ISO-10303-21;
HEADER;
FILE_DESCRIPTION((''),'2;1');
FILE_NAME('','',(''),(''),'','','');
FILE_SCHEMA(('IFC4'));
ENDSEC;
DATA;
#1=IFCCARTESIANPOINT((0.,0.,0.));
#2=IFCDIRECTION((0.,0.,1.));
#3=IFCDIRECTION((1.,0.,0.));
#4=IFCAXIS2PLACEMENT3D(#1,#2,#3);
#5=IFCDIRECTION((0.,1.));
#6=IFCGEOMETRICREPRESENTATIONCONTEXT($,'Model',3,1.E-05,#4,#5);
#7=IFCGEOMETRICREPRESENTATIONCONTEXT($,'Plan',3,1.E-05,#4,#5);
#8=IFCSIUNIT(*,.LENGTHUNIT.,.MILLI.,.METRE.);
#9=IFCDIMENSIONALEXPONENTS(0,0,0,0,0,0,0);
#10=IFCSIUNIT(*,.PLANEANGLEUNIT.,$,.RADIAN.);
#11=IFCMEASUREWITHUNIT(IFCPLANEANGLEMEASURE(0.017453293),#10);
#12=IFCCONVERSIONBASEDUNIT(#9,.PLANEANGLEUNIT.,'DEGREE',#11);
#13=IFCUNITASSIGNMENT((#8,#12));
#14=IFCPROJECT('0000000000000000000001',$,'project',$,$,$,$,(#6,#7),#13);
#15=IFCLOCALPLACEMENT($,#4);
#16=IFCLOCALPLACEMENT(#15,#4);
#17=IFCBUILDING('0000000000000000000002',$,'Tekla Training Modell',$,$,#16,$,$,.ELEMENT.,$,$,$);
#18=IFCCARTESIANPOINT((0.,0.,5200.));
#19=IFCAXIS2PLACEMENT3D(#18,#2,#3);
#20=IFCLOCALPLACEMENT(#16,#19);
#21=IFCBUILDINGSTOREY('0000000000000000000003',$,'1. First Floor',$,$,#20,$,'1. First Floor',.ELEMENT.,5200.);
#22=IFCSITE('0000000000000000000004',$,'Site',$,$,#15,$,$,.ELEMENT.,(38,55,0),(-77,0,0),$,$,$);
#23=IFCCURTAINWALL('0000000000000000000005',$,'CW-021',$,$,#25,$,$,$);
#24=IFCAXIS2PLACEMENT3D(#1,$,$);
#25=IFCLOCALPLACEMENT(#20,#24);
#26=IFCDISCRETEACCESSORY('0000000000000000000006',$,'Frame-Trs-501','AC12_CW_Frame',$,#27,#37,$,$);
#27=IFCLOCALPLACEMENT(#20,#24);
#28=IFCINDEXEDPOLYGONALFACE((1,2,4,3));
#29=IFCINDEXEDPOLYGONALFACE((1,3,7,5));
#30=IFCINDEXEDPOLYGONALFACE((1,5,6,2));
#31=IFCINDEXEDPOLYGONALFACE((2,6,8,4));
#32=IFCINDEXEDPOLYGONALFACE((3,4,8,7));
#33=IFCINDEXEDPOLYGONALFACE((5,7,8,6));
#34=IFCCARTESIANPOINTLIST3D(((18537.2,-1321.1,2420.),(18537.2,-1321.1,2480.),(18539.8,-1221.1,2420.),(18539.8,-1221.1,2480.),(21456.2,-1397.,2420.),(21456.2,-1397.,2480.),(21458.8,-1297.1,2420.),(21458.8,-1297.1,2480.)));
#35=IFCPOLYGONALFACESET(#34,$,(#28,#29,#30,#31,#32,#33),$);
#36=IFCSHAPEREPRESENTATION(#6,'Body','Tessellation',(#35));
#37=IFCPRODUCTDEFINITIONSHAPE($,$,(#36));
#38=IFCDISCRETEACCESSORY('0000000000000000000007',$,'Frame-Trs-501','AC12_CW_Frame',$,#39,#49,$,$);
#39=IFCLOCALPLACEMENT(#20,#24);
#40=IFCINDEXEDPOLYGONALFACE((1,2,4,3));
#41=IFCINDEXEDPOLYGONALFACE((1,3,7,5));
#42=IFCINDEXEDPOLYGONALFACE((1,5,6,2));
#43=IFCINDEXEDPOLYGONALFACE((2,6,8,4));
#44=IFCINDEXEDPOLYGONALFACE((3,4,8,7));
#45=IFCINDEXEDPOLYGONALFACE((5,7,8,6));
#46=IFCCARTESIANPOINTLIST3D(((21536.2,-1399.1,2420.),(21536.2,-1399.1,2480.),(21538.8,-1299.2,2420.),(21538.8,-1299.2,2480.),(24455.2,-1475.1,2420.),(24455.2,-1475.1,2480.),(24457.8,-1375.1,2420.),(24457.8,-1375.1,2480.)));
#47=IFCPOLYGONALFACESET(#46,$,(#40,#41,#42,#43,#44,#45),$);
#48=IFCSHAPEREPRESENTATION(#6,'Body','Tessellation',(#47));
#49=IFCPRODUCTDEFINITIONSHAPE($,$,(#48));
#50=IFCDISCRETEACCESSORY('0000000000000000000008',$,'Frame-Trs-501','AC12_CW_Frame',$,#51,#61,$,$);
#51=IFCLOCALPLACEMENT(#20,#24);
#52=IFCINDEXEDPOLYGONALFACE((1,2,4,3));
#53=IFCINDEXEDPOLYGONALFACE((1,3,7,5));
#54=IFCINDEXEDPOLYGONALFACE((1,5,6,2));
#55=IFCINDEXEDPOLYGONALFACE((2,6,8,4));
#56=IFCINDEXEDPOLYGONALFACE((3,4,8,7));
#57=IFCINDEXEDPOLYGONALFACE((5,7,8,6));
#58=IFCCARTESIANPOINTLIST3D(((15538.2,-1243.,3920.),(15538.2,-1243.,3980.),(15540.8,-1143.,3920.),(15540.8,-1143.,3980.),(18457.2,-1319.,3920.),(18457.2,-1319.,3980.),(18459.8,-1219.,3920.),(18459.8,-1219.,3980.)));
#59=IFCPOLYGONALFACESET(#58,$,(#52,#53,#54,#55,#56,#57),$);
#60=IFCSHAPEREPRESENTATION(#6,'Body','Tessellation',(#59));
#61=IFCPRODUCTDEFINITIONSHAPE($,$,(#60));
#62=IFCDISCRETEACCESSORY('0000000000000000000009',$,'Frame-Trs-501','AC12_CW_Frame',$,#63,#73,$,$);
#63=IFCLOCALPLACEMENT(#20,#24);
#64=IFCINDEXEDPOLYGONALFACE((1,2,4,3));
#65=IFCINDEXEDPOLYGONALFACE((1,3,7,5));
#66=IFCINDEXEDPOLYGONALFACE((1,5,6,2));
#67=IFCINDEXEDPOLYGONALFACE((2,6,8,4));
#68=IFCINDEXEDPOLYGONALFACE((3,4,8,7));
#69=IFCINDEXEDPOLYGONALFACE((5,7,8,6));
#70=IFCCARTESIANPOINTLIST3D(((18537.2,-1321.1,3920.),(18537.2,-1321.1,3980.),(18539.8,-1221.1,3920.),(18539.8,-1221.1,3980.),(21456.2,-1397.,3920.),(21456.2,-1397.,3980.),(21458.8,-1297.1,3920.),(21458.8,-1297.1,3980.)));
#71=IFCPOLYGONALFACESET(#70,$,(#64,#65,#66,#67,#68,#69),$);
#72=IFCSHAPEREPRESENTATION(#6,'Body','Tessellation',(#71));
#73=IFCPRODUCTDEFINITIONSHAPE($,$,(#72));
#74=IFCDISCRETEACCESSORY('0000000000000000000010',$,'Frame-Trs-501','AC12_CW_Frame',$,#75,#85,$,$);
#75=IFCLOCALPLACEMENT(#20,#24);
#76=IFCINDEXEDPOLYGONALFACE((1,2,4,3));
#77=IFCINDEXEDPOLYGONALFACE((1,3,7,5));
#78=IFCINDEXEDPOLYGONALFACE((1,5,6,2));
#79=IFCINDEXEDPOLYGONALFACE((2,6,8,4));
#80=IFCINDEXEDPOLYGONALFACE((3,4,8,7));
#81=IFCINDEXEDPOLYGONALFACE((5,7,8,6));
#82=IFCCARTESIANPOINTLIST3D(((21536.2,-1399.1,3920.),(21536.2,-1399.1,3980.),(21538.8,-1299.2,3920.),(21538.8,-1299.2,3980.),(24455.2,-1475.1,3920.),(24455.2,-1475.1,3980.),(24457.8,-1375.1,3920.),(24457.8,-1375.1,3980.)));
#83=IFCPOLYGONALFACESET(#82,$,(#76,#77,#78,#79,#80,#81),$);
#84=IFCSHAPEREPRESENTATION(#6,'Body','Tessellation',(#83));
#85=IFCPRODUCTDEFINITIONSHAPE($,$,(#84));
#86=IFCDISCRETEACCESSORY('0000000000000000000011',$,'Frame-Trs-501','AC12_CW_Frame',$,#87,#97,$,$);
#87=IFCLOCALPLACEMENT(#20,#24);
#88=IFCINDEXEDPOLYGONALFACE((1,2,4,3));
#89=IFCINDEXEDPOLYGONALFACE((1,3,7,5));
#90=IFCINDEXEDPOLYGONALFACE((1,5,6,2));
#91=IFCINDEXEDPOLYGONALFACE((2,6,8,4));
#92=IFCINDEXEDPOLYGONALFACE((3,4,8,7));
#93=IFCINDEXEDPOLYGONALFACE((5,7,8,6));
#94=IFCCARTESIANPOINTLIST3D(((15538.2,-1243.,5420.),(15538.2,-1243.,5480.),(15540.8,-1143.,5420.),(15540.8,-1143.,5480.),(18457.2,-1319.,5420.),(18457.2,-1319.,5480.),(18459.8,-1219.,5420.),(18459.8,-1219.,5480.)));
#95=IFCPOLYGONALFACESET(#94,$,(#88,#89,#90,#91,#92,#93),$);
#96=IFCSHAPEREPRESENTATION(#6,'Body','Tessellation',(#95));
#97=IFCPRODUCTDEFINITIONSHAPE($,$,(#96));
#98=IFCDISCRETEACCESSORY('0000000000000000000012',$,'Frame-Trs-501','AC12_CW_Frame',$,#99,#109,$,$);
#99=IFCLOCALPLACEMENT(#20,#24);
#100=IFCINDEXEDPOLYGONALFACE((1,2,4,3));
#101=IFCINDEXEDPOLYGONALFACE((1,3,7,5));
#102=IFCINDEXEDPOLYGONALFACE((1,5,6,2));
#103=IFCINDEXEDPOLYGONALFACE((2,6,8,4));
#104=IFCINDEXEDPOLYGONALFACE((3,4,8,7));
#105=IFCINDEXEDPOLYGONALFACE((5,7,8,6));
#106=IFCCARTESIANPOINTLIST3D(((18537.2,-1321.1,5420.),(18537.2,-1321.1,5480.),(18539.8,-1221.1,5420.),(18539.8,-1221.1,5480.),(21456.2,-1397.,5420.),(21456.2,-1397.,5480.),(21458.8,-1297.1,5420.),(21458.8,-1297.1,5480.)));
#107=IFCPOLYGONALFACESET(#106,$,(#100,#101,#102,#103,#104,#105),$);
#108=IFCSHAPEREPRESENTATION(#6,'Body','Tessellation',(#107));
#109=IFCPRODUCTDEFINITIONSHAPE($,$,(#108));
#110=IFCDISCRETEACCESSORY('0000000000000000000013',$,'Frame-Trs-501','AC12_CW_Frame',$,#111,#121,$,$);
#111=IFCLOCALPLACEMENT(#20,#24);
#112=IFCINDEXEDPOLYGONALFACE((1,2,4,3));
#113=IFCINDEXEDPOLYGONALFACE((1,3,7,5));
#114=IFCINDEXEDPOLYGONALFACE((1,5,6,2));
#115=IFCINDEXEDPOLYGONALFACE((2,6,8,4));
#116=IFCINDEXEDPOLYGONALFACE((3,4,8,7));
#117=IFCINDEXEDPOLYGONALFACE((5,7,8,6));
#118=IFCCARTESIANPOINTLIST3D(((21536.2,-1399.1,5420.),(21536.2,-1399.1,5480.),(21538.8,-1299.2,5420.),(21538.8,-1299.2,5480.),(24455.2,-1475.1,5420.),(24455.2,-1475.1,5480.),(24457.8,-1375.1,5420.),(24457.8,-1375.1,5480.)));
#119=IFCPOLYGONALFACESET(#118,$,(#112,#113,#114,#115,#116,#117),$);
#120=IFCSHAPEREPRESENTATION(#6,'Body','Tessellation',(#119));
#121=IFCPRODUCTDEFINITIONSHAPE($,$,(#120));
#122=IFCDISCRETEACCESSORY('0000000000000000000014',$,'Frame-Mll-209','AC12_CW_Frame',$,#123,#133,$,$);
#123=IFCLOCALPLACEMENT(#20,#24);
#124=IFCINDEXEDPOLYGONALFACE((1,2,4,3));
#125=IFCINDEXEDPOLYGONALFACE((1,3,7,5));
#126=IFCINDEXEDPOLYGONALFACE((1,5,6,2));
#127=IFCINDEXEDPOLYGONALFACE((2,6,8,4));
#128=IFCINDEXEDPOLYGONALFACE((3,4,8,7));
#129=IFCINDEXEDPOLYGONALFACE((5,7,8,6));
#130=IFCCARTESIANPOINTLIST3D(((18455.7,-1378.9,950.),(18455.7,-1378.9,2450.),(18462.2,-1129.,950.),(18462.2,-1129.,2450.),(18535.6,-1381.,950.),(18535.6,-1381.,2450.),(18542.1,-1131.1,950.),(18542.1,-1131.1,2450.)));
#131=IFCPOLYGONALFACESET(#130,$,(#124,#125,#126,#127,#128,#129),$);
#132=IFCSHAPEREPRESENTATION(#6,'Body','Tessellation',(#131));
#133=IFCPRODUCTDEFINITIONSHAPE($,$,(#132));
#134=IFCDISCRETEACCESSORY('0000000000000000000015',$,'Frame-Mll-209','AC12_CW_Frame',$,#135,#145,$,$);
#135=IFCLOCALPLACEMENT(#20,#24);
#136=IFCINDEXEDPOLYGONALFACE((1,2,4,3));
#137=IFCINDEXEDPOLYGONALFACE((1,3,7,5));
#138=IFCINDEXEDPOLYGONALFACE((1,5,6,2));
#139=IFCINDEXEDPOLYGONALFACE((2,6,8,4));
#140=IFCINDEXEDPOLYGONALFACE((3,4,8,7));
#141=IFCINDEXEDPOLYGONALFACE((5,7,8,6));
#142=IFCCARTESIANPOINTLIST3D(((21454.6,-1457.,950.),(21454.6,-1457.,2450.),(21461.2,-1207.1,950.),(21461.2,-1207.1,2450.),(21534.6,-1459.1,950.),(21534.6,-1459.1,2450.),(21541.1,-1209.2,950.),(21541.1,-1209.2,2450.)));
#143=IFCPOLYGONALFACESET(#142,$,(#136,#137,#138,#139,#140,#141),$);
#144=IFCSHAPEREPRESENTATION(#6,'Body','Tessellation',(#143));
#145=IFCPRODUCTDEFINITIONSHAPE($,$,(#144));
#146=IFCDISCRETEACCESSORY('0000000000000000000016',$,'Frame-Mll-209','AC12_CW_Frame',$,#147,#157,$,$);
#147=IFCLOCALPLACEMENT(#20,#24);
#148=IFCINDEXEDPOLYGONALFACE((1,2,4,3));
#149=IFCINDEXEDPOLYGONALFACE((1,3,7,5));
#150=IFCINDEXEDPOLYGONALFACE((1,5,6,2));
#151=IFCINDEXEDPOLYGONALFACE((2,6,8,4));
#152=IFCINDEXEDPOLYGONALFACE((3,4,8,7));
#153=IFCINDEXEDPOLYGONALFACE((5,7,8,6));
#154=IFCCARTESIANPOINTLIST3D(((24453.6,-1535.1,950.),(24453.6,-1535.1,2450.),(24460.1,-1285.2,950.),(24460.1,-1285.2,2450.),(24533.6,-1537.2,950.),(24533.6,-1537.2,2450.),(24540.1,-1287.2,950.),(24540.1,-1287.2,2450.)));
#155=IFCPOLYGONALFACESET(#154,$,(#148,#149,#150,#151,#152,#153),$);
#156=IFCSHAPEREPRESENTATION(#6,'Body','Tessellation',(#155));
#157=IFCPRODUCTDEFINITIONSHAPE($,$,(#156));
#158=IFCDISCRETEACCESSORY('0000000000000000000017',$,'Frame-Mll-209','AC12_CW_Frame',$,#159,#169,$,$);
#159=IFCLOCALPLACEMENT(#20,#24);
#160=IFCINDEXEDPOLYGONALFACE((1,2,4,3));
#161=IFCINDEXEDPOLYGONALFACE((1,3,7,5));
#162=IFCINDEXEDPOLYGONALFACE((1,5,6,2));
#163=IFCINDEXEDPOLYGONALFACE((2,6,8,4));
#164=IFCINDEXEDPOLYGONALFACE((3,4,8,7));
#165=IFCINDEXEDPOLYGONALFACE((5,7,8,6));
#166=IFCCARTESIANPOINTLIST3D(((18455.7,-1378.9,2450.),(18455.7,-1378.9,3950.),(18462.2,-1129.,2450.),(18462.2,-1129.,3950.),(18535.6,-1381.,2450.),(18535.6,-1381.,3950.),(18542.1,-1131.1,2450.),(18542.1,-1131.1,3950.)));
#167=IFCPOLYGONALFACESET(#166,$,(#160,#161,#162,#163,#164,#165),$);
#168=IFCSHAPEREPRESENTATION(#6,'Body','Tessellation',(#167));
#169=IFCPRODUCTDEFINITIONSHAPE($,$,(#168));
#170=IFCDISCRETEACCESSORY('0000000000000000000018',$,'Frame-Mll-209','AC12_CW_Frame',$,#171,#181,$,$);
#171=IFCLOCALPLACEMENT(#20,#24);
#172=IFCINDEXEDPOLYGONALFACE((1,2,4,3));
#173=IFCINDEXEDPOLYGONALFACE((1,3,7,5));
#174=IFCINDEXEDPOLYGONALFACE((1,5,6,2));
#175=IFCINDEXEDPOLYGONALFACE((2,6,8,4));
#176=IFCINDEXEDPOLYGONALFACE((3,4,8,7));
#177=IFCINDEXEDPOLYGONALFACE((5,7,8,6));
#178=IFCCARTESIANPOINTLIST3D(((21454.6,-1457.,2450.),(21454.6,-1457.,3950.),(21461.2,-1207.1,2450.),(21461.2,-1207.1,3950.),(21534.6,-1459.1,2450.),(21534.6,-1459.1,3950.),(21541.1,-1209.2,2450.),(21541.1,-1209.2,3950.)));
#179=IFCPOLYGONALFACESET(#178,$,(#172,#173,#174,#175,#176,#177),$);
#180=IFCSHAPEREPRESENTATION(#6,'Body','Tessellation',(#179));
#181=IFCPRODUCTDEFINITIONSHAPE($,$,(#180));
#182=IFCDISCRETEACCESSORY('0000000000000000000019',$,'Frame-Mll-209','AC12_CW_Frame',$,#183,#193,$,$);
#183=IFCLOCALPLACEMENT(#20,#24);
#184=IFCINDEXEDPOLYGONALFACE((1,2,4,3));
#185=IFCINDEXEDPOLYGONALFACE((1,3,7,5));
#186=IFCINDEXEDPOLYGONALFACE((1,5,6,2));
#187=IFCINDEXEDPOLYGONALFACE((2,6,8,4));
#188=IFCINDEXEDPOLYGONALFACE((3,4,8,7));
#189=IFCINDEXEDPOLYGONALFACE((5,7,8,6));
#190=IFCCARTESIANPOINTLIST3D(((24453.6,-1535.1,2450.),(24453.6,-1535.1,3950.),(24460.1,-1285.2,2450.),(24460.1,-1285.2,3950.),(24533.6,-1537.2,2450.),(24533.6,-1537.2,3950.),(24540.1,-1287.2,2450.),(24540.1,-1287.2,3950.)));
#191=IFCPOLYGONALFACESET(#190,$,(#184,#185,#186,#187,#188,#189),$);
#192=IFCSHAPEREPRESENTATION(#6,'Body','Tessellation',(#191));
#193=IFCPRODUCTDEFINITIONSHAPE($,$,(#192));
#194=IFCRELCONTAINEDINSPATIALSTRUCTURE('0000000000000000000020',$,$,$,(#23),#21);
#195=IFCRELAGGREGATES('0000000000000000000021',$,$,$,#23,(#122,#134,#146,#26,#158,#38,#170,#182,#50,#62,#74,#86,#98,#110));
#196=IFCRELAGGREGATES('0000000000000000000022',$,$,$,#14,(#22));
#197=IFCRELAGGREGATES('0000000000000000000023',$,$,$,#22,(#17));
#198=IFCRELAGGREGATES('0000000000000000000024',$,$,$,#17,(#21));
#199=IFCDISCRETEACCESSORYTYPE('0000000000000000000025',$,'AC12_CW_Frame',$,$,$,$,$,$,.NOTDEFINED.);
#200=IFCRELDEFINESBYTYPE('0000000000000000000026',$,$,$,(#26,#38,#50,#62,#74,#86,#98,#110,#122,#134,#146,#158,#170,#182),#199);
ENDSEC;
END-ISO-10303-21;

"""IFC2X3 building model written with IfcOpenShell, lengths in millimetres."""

from ifc_helpers import new_model, entity, si_unit, converted_unit, direction, frame, origin_with_axes, place, context, project, spatial, polyline, outline, extrude, source, transform, mapped, type_object, element, aggregate, save


model = new_model("IFC2X3")

# Units and contexts
model_context = context("Model", 3, precision=1e-05, world=origin_with_axes(), true_north=direction((0.0, 1.0)))
plan_context = context("Plan", 3, precision=1e-05, world=origin_with_axes(), true_north=direction((0.0, 1.0)))
ifc_project = project(units=[si_unit("LENGTHUNIT", "METRE", prefix="MILLI"), converted_unit("PLANEANGLEUNIT", "DEGREE", entity("IfcPlaneAngleMeasure", 0.017453293), si_unit("PLANEANGLEUNIT", "RADIAN"), dimensions=[0, 0, 0, 0, 0, 0, 0])], contexts=[model_context, plan_context])

# Site, building, storey
site_placement = place(None, origin_with_axes())
site = spatial("IfcSite", under=ifc_project, at=site_placement, Name="Site", CompositionType="ELEMENT", RefLatitude=(38, 55, 0), RefLongitude=(-77, 0, 0))
building_placement = place(site_placement, origin_with_axes())
building = spatial("IfcBuilding", under=site, at=building_placement, Name="Tekla Training Modell", CompositionType="ELEMENT")
storey_placement = place(building_placement, frame((0.0, 0.0, 5200.0), z_axis=(0.0, 0.0, 1.0), x_axis=(1.0, 0.0, 0.0)))
storey = spatial("IfcBuildingStorey", under=building, at=storey_placement, Name="1. First Floor", LongName="1. First Floor", CompositionType="ELEMENT", Elevation=5200.0)

# Curtain wall, discrete accessories
curtain_wall_placement = place(storey_placement, frame((9500.0, -1095.8, -550.0), z_axis=(0.0, 0.0, 1.0), x_axis=(0.999661, -0.026022, 0.0)))
curtain_wall = element("IfcCurtainWall", 1, at=curtain_wall_placement, inside=storey, Name="CW-021")
discrete_accessory_type = type_object("IfcDiscreteAccessoryType", Name="AC12_CW_Frame")
shared_shape_1 = source(origin_with_axes(), model_context, "Body", "SweptSolid", [
    extrude(outline(polyline([(0.0, 0.0), (100.0, 0.0), (100.0, -2920.0), (0.0, -2920.0), (0.0, 0.0)])), origin_with_axes(), (0.0, 0.0, 1.0), 60.0),
])
discrete_accessory_1_placement = place(storey_placement, frame((18539.8, -1221.1, 2480.0), z_axis=(0.0, 0.0, -1.0), x_axis=(-0.026022, -0.999661, 0.0)))
discrete_accessory_1 = element("IfcDiscreteAccessory", 2, at=discrete_accessory_1_placement, type_object=discrete_accessory_type, Name="Frame-Trs-501", Description="AC12_CW_Frame", context=model_context, shape_type="MappedRepresentation", body=[
    mapped(shared_shape_1, transform((0.0, 0.0, 0.0), scale=1.0)),
])
discrete_accessory_2_placement = place(storey_placement, frame((21538.8, -1299.2, 2480.0), z_axis=(0.0, 0.0, -1.0), x_axis=(-0.026022, -0.999661, 0.0)))
discrete_accessory_2 = element("IfcDiscreteAccessory", 3, at=discrete_accessory_2_placement, type_object=discrete_accessory_type, Name="Frame-Trs-501", Description="AC12_CW_Frame", context=model_context, shape_type="MappedRepresentation", body=[
    mapped(shared_shape_1, transform((0.0, 0.0, 0.0), scale=1.0)),
])
discrete_accessory_3_placement = place(storey_placement, frame((15540.8, -1143.0, 3980.0), z_axis=(0.0, 0.0, -1.0), x_axis=(-0.026022, -0.999661, 0.0)))
discrete_accessory_3 = element("IfcDiscreteAccessory", 4, at=discrete_accessory_3_placement, type_object=discrete_accessory_type, Name="Frame-Trs-501", Description="AC12_CW_Frame", context=model_context, shape_type="MappedRepresentation", body=[
    mapped(shared_shape_1, transform((0.0, 0.0, 0.0), scale=1.0)),
])
discrete_accessory_4_placement = place(storey_placement, frame((18539.8, -1221.1, 3980.0), z_axis=(0.0, 0.0, -1.0), x_axis=(-0.026022, -0.999661, 0.0)))
discrete_accessory_4 = element("IfcDiscreteAccessory", 5, at=discrete_accessory_4_placement, type_object=discrete_accessory_type, Name="Frame-Trs-501", Description="AC12_CW_Frame", context=model_context, shape_type="MappedRepresentation", body=[
    mapped(shared_shape_1, transform((0.0, 0.0, 0.0), scale=1.0)),
])
discrete_accessory_5_placement = place(storey_placement, frame((21538.8, -1299.2, 3980.0), z_axis=(0.0, 0.0, -1.0), x_axis=(-0.026022, -0.999661, 0.0)))
discrete_accessory_5 = element("IfcDiscreteAccessory", 6, at=discrete_accessory_5_placement, type_object=discrete_accessory_type, Name="Frame-Trs-501", Description="AC12_CW_Frame", context=model_context, shape_type="MappedRepresentation", body=[
    mapped(shared_shape_1, transform((0.0, 0.0, 0.0), scale=1.0)),
])
discrete_accessory_6_placement = place(storey_placement, frame((15540.8, -1143.0, 5480.0), z_axis=(0.0, 0.0, -1.0), x_axis=(-0.026022, -0.999661, 0.0)))
discrete_accessory_6 = element("IfcDiscreteAccessory", 7, at=discrete_accessory_6_placement, type_object=discrete_accessory_type, Name="Frame-Trs-501", Description="AC12_CW_Frame", context=model_context, shape_type="MappedRepresentation", body=[
    mapped(shared_shape_1, transform((0.0, 0.0, 0.0), scale=1.0)),
])
discrete_accessory_7_placement = place(storey_placement, frame((18539.8, -1221.1, 5480.0), z_axis=(0.0, 0.0, -1.0), x_axis=(-0.026022, -0.999661, 0.0)))
discrete_accessory_7 = element("IfcDiscreteAccessory", 8, at=discrete_accessory_7_placement, type_object=discrete_accessory_type, Name="Frame-Trs-501", Description="AC12_CW_Frame", context=model_context, shape_type="MappedRepresentation", body=[
    mapped(shared_shape_1, transform((0.0, 0.0, 0.0), scale=1.0)),
])
discrete_accessory_8_placement = place(storey_placement, frame((21538.8, -1299.2, 5480.0), z_axis=(0.0, 0.0, -1.0), x_axis=(-0.026022, -0.999661, 0.0)))
discrete_accessory_8 = element("IfcDiscreteAccessory", 9, at=discrete_accessory_8_placement, type_object=discrete_accessory_type, Name="Frame-Trs-501", Description="AC12_CW_Frame", context=model_context, shape_type="MappedRepresentation", body=[
    mapped(shared_shape_1, transform((0.0, 0.0, 0.0), scale=1.0)),
])
shared_shape_2 = source(origin_with_axes(), model_context, "Body", "SweptSolid", [
    extrude(outline(polyline([(0.0, 0.0), (250.0, 0.0), (250.0, -1500.0), (0.0, -1500.0), (0.0, 0.0)])), origin_with_axes(), (0.0, 0.0, 1.0), 80.0),
])
discrete_accessory_9_placement = place(storey_placement, frame((18462.2, -1129.0, 950.0), z_axis=(0.999661, -0.026022, 0.0), x_axis=(-0.026022, -0.999661, 0.0)))
discrete_accessory_9 = element("IfcDiscreteAccessory", 10, at=discrete_accessory_9_placement, type_object=discrete_accessory_type, Name="Frame-Mll-209", Description="AC12_CW_Frame", context=model_context, shape_type="MappedRepresentation", body=[
    mapped(shared_shape_2, transform((0.0, 0.0, 0.0), scale=1.0)),
])
discrete_accessory_10_placement = place(storey_placement, frame((21461.2, -1207.1, 950.0), z_axis=(0.999661, -0.026022, 0.0), x_axis=(-0.026022, -0.999661, 0.0)))
discrete_accessory_10 = element("IfcDiscreteAccessory", 11, at=discrete_accessory_10_placement, type_object=discrete_accessory_type, Name="Frame-Mll-209", Description="AC12_CW_Frame", context=model_context, shape_type="MappedRepresentation", body=[
    mapped(shared_shape_2, transform((0.0, 0.0, 0.0), scale=1.0)),
])
discrete_accessory_11_placement = place(storey_placement, frame((24460.1, -1285.2, 950.0), z_axis=(0.999661, -0.026022, 0.0), x_axis=(-0.026022, -0.999661, 0.0)))
discrete_accessory_11 = element("IfcDiscreteAccessory", 12, at=discrete_accessory_11_placement, type_object=discrete_accessory_type, Name="Frame-Mll-209", Description="AC12_CW_Frame", context=model_context, shape_type="MappedRepresentation", body=[
    mapped(shared_shape_2, transform((0.0, 0.0, 0.0), scale=1.0)),
])
discrete_accessory_12_placement = place(storey_placement, frame((18462.2, -1129.0, 2450.0), z_axis=(0.999661, -0.026022, 0.0), x_axis=(-0.026022, -0.999661, 0.0)))
discrete_accessory_12 = element("IfcDiscreteAccessory", 13, at=discrete_accessory_12_placement, type_object=discrete_accessory_type, Name="Frame-Mll-209", Description="AC12_CW_Frame", context=model_context, shape_type="MappedRepresentation", body=[
    mapped(shared_shape_2, transform((0.0, 0.0, 0.0), scale=1.0)),
])
discrete_accessory_13_placement = place(storey_placement, frame((21461.2, -1207.1, 2450.0), z_axis=(0.999661, -0.026022, 0.0), x_axis=(-0.026022, -0.999661, 0.0)))
discrete_accessory_13 = element("IfcDiscreteAccessory", 14, at=discrete_accessory_13_placement, type_object=discrete_accessory_type, Name="Frame-Mll-209", Description="AC12_CW_Frame", context=model_context, shape_type="MappedRepresentation", body=[
    mapped(shared_shape_2, transform((0.0, 0.0, 0.0), scale=1.0)),
])
discrete_accessory_14_placement = place(storey_placement, frame((24460.1, -1285.2, 2450.0), z_axis=(0.999661, -0.026022, 0.0), x_axis=(-0.026022, -0.999661, 0.0)))
discrete_accessory_14 = element("IfcDiscreteAccessory", 15, at=discrete_accessory_14_placement, type_object=discrete_accessory_type, Name="Frame-Mll-209", Description="AC12_CW_Frame", context=model_context, shape_type="MappedRepresentation", body=[
    mapped(shared_shape_2, transform((0.0, 0.0, 0.0), scale=1.0)),
])
aggregate(curtain_wall, [discrete_accessory_9, discrete_accessory_10, discrete_accessory_11, discrete_accessory_1, discrete_accessory_12, discrete_accessory_2, discrete_accessory_13, discrete_accessory_14, discrete_accessory_3, discrete_accessory_4, discrete_accessory_5, discrete_accessory_6, discrete_accessory_7, discrete_accessory_8])

save(model, "model.ifc")
